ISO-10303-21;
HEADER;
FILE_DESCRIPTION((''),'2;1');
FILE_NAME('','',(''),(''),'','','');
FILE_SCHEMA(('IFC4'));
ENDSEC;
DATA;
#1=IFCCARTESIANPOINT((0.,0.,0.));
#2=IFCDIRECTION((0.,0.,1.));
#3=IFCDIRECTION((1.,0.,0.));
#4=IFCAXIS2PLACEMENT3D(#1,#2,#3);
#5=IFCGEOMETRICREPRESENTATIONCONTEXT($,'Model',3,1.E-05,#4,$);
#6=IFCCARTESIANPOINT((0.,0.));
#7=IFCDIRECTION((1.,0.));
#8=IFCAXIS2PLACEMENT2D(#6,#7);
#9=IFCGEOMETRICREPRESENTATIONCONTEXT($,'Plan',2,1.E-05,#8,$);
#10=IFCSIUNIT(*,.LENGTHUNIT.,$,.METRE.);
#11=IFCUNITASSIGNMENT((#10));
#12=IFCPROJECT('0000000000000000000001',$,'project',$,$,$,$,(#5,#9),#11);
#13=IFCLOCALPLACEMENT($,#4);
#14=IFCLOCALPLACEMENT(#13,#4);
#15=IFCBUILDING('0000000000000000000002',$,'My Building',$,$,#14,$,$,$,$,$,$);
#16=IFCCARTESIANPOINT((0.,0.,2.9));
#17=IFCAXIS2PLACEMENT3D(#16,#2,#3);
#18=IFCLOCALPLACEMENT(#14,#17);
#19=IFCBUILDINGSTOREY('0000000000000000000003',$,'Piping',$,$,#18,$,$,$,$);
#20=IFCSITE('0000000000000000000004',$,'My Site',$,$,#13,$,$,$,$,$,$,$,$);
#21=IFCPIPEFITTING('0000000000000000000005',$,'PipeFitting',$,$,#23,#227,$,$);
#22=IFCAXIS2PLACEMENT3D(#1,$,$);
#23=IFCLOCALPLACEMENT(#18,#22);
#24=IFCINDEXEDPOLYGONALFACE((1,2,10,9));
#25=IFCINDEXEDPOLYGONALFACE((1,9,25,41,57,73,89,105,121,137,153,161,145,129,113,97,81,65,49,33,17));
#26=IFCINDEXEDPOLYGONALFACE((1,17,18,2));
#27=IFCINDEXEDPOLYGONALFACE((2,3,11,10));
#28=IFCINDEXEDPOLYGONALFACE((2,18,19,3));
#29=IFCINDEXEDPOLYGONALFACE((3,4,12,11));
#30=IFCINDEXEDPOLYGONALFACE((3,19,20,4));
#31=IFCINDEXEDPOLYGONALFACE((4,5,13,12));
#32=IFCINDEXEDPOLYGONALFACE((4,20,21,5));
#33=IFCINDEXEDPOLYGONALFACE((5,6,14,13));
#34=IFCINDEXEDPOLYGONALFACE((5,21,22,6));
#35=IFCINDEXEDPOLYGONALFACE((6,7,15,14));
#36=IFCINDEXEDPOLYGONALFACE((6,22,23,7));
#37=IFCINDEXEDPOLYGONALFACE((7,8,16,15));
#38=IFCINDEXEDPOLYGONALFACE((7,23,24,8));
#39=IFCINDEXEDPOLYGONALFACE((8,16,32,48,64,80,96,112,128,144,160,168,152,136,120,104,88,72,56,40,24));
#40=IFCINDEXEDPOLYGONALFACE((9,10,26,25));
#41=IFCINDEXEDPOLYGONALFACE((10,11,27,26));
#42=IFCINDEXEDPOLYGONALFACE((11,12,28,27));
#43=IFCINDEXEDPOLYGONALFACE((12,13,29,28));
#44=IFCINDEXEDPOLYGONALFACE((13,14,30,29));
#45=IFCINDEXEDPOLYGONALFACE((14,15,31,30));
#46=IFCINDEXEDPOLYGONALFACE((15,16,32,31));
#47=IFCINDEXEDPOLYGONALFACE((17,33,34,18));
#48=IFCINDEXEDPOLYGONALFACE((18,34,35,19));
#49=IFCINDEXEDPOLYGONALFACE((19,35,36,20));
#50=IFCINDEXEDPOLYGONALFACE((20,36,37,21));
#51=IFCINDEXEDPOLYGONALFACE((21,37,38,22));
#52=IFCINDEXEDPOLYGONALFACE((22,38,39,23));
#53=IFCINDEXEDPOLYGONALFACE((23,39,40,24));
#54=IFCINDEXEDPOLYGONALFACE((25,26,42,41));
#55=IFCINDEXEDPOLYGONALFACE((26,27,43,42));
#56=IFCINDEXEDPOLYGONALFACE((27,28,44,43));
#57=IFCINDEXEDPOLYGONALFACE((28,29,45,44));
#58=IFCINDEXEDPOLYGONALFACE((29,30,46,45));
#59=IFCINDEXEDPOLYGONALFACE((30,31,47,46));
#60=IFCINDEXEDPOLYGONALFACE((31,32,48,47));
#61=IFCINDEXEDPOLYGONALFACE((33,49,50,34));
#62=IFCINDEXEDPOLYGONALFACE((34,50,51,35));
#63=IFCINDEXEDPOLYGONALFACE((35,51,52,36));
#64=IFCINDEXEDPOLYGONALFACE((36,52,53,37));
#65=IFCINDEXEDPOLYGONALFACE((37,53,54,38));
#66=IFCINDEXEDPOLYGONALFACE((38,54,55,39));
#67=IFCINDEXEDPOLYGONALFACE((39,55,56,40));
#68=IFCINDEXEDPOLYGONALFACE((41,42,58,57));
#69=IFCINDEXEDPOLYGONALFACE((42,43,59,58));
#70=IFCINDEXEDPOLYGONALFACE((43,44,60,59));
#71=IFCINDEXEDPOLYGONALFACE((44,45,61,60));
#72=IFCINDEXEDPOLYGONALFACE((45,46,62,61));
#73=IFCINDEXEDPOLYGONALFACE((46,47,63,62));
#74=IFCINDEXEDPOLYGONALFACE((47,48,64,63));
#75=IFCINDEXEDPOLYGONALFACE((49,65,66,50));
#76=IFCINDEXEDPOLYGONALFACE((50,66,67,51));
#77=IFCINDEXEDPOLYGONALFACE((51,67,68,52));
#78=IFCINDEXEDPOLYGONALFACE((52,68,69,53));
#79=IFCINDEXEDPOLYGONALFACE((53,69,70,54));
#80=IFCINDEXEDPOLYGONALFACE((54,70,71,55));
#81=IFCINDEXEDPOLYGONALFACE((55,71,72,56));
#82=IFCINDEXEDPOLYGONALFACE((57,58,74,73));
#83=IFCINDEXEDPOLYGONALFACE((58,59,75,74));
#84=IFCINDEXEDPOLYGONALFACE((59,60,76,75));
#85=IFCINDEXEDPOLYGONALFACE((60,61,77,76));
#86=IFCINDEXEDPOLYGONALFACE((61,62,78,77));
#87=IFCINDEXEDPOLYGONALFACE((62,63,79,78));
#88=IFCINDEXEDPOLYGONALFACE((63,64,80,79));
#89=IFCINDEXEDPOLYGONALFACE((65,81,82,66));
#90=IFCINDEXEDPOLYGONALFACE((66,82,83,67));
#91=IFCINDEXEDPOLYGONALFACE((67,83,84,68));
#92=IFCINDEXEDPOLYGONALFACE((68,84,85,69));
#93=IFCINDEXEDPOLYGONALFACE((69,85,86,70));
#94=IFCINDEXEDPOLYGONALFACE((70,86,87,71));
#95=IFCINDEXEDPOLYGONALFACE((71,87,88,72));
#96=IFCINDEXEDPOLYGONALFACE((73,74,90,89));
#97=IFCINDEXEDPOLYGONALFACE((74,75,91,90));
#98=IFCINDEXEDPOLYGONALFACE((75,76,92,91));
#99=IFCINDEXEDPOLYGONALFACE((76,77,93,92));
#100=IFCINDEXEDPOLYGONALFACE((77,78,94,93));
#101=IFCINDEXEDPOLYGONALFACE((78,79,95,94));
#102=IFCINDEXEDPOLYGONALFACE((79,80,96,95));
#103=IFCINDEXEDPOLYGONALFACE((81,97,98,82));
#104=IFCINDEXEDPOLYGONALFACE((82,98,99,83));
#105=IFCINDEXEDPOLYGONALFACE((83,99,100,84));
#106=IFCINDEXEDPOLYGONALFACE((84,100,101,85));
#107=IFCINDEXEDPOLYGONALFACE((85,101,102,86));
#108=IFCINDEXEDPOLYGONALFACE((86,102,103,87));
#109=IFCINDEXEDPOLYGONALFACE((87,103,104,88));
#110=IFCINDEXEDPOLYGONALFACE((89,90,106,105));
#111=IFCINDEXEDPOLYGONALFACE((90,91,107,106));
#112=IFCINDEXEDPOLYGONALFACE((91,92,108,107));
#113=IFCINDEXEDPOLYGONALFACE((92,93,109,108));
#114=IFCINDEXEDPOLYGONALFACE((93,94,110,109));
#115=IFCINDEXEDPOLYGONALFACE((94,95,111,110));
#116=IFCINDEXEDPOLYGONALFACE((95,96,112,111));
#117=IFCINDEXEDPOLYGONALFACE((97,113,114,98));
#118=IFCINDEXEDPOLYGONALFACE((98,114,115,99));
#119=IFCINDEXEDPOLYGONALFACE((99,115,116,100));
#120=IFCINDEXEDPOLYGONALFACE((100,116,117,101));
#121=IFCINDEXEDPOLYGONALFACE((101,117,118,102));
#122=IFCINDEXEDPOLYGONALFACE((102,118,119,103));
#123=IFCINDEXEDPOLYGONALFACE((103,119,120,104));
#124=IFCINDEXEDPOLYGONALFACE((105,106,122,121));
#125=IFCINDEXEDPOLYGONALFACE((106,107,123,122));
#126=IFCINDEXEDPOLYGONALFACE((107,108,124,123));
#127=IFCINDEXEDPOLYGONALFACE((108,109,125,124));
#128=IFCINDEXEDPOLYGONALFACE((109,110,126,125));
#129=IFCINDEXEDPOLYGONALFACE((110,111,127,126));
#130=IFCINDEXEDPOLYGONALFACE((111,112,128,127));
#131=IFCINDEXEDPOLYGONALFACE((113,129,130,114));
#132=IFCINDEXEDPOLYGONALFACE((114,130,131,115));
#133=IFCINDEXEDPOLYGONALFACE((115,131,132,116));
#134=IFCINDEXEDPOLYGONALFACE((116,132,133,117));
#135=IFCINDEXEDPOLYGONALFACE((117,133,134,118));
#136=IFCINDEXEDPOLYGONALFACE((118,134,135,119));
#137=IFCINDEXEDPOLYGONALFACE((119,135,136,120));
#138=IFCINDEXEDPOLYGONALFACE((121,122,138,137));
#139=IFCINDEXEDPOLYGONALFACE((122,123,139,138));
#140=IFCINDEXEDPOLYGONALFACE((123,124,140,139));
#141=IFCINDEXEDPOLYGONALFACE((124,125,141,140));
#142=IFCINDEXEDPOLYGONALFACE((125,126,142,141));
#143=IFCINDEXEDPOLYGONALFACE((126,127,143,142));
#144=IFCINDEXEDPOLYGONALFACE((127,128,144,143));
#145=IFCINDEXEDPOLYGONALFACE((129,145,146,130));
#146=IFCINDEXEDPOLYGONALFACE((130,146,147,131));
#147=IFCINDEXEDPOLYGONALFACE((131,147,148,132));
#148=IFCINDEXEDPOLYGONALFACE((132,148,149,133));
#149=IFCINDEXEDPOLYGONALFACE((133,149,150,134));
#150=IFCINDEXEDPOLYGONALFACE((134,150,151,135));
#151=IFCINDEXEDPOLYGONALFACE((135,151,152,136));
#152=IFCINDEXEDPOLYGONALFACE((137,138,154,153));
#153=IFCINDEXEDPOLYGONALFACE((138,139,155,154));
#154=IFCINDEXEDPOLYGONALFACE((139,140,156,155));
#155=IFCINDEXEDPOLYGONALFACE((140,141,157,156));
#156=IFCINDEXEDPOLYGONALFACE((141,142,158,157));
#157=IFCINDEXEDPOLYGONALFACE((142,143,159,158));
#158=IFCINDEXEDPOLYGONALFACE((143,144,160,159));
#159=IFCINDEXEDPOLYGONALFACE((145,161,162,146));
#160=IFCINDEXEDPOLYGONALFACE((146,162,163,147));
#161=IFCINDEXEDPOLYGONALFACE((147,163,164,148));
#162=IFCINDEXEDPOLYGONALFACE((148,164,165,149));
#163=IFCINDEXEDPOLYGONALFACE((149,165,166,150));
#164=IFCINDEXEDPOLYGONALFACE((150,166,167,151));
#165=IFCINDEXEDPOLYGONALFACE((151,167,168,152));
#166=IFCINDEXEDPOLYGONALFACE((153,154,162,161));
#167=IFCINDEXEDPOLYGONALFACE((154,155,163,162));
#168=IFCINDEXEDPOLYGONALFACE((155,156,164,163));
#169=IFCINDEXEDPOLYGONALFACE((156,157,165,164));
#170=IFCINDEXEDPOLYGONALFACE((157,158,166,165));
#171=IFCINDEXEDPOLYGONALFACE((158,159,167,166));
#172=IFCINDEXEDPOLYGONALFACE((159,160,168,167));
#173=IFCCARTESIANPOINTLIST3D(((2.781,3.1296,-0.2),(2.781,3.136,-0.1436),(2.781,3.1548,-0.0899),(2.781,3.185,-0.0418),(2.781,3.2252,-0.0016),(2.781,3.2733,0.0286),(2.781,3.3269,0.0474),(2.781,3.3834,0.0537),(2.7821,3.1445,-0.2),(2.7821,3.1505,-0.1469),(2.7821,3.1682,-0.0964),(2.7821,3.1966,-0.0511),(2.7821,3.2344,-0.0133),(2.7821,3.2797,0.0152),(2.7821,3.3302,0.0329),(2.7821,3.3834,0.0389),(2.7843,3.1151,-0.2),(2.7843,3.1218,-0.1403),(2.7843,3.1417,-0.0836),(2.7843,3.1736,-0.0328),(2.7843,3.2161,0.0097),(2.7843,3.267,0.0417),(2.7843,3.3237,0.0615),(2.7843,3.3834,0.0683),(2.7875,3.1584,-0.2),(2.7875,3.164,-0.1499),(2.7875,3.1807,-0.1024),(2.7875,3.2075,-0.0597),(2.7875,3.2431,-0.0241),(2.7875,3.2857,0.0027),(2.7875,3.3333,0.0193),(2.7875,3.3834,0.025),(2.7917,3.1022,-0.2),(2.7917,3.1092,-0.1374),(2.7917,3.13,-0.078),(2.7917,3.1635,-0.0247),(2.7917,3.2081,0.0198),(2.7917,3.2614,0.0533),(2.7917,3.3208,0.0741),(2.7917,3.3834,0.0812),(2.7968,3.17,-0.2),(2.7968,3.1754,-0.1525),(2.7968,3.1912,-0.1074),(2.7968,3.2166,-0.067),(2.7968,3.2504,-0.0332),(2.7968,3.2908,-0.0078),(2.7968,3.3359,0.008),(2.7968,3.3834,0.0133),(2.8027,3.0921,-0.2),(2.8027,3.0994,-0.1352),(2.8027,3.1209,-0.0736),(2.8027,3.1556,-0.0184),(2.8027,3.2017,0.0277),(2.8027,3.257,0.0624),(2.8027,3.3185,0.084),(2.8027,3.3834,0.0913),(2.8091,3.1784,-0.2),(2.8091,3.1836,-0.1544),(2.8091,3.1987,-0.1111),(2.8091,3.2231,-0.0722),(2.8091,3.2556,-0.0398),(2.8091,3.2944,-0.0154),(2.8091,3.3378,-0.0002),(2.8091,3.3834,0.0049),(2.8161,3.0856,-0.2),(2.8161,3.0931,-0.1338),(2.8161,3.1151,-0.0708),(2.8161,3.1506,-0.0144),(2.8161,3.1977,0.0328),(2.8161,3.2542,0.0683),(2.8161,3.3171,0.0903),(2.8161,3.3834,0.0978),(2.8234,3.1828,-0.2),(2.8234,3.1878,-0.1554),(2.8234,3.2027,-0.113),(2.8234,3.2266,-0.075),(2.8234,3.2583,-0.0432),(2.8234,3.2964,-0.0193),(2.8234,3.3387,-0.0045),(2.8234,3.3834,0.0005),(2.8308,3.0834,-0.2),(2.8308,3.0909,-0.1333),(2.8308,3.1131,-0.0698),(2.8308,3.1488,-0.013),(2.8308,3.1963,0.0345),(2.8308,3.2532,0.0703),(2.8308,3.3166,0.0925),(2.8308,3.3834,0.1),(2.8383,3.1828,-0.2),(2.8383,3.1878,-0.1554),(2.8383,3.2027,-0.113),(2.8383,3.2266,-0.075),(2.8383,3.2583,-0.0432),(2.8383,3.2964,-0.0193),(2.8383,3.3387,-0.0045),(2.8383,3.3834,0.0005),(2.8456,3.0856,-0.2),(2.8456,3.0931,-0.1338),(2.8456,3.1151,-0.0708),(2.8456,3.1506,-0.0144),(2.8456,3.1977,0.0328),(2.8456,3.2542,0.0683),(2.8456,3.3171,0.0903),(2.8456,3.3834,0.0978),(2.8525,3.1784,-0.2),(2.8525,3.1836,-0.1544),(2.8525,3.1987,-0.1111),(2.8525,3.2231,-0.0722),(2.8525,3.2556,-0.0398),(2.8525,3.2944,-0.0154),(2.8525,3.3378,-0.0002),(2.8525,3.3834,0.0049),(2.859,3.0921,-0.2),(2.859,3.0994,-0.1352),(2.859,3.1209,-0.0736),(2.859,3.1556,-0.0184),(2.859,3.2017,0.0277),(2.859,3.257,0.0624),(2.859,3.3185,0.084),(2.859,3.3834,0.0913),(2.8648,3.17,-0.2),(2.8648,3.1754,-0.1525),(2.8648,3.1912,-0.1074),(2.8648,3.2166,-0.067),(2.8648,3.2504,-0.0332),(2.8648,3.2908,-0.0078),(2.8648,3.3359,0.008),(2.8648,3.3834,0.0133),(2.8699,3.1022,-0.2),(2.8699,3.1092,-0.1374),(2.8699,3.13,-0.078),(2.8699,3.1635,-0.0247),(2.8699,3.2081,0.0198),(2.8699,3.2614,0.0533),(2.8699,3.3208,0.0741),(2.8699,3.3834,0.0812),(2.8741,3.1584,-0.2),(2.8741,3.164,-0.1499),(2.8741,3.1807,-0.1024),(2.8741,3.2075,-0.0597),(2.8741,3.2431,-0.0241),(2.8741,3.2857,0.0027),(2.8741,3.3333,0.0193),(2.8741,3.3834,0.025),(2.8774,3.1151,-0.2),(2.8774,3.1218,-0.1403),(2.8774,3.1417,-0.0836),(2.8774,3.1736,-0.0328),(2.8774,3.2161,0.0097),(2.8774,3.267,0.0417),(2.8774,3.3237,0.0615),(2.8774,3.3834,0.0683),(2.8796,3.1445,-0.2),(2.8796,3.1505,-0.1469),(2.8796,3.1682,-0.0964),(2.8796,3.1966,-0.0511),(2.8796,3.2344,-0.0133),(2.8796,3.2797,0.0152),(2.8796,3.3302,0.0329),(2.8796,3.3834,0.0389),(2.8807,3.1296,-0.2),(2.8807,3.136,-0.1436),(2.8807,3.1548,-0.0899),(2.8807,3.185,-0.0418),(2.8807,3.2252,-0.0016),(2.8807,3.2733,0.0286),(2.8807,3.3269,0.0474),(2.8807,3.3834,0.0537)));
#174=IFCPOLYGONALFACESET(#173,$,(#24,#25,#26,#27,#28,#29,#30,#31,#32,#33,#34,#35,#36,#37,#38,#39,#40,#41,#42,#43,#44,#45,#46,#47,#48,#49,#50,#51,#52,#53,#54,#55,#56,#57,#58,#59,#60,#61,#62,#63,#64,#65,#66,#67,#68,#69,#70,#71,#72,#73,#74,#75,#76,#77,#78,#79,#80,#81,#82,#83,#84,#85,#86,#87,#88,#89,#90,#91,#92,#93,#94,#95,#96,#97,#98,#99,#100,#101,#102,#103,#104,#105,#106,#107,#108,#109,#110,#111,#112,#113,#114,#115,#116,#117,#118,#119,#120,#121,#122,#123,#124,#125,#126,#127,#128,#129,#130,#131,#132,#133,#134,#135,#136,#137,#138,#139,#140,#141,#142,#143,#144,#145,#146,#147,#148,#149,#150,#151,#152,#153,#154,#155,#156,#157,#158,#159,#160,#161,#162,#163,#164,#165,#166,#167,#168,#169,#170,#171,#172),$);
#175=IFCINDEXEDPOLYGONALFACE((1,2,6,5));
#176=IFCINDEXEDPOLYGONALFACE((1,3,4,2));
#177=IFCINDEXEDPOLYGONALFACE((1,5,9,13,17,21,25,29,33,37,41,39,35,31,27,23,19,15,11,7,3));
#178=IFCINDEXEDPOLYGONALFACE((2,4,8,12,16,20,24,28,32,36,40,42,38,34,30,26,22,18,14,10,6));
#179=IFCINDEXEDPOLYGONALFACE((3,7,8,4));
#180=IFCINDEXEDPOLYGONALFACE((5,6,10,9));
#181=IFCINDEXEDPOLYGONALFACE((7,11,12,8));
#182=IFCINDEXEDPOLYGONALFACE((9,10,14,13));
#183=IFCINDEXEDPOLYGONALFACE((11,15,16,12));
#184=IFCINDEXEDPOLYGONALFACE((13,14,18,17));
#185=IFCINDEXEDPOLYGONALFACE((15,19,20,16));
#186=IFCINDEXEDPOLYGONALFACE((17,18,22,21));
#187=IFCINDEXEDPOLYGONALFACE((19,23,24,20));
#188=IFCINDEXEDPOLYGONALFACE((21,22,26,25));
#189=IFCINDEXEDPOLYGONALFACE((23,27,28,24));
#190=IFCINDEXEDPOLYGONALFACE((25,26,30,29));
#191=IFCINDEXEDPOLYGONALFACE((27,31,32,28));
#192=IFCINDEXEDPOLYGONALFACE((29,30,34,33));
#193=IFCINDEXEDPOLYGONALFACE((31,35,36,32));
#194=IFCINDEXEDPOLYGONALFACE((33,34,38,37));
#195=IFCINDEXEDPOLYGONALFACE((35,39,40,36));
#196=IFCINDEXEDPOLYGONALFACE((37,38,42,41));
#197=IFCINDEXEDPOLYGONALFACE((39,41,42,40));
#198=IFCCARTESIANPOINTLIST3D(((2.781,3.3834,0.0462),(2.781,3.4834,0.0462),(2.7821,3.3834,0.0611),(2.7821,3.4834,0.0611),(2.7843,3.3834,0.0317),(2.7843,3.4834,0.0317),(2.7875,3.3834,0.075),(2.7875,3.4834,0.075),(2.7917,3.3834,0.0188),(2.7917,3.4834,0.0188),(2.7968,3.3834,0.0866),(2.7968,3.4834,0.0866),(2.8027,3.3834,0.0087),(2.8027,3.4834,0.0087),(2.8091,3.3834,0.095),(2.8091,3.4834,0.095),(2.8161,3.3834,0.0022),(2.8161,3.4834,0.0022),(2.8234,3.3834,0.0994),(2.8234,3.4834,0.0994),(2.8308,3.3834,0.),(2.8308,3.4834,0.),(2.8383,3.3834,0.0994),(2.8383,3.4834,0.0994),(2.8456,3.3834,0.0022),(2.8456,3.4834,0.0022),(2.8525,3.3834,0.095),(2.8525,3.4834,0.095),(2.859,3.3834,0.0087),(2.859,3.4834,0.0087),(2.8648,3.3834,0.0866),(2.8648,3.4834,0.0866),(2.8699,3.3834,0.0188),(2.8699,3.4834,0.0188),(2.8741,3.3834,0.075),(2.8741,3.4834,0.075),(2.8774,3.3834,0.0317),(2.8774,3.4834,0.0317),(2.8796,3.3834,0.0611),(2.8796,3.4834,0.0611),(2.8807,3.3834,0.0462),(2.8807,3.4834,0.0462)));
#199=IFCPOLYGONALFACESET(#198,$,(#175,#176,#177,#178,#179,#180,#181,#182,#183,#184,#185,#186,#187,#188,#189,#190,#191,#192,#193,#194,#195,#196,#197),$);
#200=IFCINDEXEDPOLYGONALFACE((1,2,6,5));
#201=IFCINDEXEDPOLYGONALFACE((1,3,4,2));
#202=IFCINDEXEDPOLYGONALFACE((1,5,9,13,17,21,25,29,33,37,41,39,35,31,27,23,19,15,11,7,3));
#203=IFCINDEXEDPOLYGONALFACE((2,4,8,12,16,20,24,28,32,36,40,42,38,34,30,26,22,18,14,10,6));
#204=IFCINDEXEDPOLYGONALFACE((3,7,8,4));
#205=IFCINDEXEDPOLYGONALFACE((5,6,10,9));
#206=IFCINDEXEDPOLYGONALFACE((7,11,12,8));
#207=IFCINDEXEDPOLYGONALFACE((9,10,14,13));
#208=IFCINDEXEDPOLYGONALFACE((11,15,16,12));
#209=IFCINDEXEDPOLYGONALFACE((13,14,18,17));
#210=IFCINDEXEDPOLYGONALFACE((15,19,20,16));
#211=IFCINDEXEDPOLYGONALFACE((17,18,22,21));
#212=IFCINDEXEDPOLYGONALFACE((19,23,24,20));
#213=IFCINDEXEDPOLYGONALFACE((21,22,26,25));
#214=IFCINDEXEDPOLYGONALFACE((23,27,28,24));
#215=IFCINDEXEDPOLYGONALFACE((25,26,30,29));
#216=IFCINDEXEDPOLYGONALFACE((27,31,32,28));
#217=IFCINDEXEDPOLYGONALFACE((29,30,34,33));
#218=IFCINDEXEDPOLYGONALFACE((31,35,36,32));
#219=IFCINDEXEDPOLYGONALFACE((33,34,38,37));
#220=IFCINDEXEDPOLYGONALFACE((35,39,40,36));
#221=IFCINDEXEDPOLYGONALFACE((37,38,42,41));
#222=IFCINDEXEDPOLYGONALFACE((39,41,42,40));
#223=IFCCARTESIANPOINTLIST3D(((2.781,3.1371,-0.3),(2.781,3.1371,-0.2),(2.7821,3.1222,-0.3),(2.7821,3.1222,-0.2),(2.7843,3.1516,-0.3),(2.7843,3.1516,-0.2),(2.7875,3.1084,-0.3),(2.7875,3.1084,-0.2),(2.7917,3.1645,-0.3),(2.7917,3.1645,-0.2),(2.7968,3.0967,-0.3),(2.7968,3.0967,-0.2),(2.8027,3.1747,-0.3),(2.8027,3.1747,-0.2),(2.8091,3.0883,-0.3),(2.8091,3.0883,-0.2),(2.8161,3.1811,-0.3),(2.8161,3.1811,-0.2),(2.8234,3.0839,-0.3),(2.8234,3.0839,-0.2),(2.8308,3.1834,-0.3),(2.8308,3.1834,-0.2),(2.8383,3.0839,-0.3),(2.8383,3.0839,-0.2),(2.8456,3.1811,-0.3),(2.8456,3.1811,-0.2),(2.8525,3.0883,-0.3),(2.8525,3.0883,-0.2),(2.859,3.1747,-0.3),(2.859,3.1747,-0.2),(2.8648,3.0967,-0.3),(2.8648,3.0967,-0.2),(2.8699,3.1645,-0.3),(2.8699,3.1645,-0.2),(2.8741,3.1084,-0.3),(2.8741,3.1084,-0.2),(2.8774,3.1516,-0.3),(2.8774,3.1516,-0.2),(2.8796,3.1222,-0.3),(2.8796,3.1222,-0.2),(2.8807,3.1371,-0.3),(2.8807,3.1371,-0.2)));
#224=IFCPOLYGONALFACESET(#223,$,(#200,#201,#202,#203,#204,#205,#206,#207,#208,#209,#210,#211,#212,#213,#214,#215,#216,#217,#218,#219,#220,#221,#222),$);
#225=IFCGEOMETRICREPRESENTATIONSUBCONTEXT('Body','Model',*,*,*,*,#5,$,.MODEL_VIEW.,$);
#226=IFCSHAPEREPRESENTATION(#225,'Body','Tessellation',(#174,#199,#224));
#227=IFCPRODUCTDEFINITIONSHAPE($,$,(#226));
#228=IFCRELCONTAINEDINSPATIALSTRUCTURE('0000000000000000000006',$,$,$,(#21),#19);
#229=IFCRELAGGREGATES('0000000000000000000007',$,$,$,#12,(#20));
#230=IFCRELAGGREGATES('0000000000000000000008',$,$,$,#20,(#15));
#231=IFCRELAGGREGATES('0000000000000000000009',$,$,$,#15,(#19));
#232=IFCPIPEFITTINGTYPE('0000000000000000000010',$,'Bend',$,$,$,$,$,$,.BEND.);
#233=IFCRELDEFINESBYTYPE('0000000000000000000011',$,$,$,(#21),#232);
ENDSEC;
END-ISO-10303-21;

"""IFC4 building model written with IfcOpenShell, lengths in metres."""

from ifc_helpers import new_model, entity, si_unit, frame, origin_with_axes, origin_2d_with_axis, place, context, subcontext, project, spatial, circle, extrude, source, transform, mapped, type_object, type_shapes, element, save


model = new_model("IFC4")

# Units and contexts
model_context = context("Model", 3, precision=1e-05, world=origin_with_axes())
plan_context = context("Plan", 2, precision=1e-05, world=origin_2d_with_axis())
body_context = subcontext(model_context, "Body", "Model", "MODEL_VIEW")
ifc_project = project(units=[si_unit("LENGTHUNIT", "METRE")], contexts=[model_context, plan_context])

# Site, building, storey
site_placement = place(None, origin_with_axes())
site = spatial("IfcSite", under=ifc_project, at=site_placement, Name="My Site")
building_placement = place(site_placement, origin_with_axes())
building = spatial("IfcBuilding", under=site, at=building_placement, Name="My Building")
storey_placement = place(building_placement, frame((0.0, 0.0, 2.9), z_axis=(0.0, 0.0, 1.0), x_axis=(1.0, 0.0, 0.0)))
storey = spatial("IfcBuildingStorey", under=building, at=storey_placement, Name="Piping")

# Pipe fitting
pipe_fitting_type_1 = type_object("IfcPipeFittingType", Name="Bend", PredefinedType="BEND")
shared_shape = source(origin_with_axes(), body_context, "Body", "SolidModel", [
    entity("IfcSweptDiskSolid", entity("IfcIndexedPolyCurve", entity("IfcCartesianPointList3D", [[0.0, 0.0, -0.1], [0.0732, 0.0, -0.2768], [0.25, 0.0, -0.35]]), [entity("IfcArcIndex", [1, 2, 3])]), 0.05),
    extrude(circle(Radius=0.05), origin_with_axes(), (0.0, 0.0, -1.0), 0.1),
    extrude(circle(Radius=0.05), frame((0.25, 0.0, -0.35), z_axis=(1.0, 0.0, 0.0), x_axis=(0.0, 0.0, 1.0)), (0.0, 0.0, 1.0), 0.1),
])
type_shapes(pipe_fitting_type_1, [shared_shape])
for number, where, z_axis, x_axis, name in (
    (1, (2.8308, 3.4834, 0.05), (0.0, 1.0, 0.0), (0.0, 0.0, -1.0), "PipeFitting"),
):
    element("IfcPipeFitting", number, at=place(storey_placement, frame(where, z_axis=z_axis, x_axis=x_axis)), inside=storey, type_object=pipe_fitting_type_1, Name=name, context=body_context, shape_type="MappedRepresentation", body=[
        mapped(shared_shape, transform((0.0, 0.0, 0.0), x_axis=(1.0, 0.0, 0.0), y_axis=(0.0, 1.0, 0.0), z_axis=(0.0, 0.0, 1.0), scale=1.0)),
    ])

save(model, "model.ifc")
